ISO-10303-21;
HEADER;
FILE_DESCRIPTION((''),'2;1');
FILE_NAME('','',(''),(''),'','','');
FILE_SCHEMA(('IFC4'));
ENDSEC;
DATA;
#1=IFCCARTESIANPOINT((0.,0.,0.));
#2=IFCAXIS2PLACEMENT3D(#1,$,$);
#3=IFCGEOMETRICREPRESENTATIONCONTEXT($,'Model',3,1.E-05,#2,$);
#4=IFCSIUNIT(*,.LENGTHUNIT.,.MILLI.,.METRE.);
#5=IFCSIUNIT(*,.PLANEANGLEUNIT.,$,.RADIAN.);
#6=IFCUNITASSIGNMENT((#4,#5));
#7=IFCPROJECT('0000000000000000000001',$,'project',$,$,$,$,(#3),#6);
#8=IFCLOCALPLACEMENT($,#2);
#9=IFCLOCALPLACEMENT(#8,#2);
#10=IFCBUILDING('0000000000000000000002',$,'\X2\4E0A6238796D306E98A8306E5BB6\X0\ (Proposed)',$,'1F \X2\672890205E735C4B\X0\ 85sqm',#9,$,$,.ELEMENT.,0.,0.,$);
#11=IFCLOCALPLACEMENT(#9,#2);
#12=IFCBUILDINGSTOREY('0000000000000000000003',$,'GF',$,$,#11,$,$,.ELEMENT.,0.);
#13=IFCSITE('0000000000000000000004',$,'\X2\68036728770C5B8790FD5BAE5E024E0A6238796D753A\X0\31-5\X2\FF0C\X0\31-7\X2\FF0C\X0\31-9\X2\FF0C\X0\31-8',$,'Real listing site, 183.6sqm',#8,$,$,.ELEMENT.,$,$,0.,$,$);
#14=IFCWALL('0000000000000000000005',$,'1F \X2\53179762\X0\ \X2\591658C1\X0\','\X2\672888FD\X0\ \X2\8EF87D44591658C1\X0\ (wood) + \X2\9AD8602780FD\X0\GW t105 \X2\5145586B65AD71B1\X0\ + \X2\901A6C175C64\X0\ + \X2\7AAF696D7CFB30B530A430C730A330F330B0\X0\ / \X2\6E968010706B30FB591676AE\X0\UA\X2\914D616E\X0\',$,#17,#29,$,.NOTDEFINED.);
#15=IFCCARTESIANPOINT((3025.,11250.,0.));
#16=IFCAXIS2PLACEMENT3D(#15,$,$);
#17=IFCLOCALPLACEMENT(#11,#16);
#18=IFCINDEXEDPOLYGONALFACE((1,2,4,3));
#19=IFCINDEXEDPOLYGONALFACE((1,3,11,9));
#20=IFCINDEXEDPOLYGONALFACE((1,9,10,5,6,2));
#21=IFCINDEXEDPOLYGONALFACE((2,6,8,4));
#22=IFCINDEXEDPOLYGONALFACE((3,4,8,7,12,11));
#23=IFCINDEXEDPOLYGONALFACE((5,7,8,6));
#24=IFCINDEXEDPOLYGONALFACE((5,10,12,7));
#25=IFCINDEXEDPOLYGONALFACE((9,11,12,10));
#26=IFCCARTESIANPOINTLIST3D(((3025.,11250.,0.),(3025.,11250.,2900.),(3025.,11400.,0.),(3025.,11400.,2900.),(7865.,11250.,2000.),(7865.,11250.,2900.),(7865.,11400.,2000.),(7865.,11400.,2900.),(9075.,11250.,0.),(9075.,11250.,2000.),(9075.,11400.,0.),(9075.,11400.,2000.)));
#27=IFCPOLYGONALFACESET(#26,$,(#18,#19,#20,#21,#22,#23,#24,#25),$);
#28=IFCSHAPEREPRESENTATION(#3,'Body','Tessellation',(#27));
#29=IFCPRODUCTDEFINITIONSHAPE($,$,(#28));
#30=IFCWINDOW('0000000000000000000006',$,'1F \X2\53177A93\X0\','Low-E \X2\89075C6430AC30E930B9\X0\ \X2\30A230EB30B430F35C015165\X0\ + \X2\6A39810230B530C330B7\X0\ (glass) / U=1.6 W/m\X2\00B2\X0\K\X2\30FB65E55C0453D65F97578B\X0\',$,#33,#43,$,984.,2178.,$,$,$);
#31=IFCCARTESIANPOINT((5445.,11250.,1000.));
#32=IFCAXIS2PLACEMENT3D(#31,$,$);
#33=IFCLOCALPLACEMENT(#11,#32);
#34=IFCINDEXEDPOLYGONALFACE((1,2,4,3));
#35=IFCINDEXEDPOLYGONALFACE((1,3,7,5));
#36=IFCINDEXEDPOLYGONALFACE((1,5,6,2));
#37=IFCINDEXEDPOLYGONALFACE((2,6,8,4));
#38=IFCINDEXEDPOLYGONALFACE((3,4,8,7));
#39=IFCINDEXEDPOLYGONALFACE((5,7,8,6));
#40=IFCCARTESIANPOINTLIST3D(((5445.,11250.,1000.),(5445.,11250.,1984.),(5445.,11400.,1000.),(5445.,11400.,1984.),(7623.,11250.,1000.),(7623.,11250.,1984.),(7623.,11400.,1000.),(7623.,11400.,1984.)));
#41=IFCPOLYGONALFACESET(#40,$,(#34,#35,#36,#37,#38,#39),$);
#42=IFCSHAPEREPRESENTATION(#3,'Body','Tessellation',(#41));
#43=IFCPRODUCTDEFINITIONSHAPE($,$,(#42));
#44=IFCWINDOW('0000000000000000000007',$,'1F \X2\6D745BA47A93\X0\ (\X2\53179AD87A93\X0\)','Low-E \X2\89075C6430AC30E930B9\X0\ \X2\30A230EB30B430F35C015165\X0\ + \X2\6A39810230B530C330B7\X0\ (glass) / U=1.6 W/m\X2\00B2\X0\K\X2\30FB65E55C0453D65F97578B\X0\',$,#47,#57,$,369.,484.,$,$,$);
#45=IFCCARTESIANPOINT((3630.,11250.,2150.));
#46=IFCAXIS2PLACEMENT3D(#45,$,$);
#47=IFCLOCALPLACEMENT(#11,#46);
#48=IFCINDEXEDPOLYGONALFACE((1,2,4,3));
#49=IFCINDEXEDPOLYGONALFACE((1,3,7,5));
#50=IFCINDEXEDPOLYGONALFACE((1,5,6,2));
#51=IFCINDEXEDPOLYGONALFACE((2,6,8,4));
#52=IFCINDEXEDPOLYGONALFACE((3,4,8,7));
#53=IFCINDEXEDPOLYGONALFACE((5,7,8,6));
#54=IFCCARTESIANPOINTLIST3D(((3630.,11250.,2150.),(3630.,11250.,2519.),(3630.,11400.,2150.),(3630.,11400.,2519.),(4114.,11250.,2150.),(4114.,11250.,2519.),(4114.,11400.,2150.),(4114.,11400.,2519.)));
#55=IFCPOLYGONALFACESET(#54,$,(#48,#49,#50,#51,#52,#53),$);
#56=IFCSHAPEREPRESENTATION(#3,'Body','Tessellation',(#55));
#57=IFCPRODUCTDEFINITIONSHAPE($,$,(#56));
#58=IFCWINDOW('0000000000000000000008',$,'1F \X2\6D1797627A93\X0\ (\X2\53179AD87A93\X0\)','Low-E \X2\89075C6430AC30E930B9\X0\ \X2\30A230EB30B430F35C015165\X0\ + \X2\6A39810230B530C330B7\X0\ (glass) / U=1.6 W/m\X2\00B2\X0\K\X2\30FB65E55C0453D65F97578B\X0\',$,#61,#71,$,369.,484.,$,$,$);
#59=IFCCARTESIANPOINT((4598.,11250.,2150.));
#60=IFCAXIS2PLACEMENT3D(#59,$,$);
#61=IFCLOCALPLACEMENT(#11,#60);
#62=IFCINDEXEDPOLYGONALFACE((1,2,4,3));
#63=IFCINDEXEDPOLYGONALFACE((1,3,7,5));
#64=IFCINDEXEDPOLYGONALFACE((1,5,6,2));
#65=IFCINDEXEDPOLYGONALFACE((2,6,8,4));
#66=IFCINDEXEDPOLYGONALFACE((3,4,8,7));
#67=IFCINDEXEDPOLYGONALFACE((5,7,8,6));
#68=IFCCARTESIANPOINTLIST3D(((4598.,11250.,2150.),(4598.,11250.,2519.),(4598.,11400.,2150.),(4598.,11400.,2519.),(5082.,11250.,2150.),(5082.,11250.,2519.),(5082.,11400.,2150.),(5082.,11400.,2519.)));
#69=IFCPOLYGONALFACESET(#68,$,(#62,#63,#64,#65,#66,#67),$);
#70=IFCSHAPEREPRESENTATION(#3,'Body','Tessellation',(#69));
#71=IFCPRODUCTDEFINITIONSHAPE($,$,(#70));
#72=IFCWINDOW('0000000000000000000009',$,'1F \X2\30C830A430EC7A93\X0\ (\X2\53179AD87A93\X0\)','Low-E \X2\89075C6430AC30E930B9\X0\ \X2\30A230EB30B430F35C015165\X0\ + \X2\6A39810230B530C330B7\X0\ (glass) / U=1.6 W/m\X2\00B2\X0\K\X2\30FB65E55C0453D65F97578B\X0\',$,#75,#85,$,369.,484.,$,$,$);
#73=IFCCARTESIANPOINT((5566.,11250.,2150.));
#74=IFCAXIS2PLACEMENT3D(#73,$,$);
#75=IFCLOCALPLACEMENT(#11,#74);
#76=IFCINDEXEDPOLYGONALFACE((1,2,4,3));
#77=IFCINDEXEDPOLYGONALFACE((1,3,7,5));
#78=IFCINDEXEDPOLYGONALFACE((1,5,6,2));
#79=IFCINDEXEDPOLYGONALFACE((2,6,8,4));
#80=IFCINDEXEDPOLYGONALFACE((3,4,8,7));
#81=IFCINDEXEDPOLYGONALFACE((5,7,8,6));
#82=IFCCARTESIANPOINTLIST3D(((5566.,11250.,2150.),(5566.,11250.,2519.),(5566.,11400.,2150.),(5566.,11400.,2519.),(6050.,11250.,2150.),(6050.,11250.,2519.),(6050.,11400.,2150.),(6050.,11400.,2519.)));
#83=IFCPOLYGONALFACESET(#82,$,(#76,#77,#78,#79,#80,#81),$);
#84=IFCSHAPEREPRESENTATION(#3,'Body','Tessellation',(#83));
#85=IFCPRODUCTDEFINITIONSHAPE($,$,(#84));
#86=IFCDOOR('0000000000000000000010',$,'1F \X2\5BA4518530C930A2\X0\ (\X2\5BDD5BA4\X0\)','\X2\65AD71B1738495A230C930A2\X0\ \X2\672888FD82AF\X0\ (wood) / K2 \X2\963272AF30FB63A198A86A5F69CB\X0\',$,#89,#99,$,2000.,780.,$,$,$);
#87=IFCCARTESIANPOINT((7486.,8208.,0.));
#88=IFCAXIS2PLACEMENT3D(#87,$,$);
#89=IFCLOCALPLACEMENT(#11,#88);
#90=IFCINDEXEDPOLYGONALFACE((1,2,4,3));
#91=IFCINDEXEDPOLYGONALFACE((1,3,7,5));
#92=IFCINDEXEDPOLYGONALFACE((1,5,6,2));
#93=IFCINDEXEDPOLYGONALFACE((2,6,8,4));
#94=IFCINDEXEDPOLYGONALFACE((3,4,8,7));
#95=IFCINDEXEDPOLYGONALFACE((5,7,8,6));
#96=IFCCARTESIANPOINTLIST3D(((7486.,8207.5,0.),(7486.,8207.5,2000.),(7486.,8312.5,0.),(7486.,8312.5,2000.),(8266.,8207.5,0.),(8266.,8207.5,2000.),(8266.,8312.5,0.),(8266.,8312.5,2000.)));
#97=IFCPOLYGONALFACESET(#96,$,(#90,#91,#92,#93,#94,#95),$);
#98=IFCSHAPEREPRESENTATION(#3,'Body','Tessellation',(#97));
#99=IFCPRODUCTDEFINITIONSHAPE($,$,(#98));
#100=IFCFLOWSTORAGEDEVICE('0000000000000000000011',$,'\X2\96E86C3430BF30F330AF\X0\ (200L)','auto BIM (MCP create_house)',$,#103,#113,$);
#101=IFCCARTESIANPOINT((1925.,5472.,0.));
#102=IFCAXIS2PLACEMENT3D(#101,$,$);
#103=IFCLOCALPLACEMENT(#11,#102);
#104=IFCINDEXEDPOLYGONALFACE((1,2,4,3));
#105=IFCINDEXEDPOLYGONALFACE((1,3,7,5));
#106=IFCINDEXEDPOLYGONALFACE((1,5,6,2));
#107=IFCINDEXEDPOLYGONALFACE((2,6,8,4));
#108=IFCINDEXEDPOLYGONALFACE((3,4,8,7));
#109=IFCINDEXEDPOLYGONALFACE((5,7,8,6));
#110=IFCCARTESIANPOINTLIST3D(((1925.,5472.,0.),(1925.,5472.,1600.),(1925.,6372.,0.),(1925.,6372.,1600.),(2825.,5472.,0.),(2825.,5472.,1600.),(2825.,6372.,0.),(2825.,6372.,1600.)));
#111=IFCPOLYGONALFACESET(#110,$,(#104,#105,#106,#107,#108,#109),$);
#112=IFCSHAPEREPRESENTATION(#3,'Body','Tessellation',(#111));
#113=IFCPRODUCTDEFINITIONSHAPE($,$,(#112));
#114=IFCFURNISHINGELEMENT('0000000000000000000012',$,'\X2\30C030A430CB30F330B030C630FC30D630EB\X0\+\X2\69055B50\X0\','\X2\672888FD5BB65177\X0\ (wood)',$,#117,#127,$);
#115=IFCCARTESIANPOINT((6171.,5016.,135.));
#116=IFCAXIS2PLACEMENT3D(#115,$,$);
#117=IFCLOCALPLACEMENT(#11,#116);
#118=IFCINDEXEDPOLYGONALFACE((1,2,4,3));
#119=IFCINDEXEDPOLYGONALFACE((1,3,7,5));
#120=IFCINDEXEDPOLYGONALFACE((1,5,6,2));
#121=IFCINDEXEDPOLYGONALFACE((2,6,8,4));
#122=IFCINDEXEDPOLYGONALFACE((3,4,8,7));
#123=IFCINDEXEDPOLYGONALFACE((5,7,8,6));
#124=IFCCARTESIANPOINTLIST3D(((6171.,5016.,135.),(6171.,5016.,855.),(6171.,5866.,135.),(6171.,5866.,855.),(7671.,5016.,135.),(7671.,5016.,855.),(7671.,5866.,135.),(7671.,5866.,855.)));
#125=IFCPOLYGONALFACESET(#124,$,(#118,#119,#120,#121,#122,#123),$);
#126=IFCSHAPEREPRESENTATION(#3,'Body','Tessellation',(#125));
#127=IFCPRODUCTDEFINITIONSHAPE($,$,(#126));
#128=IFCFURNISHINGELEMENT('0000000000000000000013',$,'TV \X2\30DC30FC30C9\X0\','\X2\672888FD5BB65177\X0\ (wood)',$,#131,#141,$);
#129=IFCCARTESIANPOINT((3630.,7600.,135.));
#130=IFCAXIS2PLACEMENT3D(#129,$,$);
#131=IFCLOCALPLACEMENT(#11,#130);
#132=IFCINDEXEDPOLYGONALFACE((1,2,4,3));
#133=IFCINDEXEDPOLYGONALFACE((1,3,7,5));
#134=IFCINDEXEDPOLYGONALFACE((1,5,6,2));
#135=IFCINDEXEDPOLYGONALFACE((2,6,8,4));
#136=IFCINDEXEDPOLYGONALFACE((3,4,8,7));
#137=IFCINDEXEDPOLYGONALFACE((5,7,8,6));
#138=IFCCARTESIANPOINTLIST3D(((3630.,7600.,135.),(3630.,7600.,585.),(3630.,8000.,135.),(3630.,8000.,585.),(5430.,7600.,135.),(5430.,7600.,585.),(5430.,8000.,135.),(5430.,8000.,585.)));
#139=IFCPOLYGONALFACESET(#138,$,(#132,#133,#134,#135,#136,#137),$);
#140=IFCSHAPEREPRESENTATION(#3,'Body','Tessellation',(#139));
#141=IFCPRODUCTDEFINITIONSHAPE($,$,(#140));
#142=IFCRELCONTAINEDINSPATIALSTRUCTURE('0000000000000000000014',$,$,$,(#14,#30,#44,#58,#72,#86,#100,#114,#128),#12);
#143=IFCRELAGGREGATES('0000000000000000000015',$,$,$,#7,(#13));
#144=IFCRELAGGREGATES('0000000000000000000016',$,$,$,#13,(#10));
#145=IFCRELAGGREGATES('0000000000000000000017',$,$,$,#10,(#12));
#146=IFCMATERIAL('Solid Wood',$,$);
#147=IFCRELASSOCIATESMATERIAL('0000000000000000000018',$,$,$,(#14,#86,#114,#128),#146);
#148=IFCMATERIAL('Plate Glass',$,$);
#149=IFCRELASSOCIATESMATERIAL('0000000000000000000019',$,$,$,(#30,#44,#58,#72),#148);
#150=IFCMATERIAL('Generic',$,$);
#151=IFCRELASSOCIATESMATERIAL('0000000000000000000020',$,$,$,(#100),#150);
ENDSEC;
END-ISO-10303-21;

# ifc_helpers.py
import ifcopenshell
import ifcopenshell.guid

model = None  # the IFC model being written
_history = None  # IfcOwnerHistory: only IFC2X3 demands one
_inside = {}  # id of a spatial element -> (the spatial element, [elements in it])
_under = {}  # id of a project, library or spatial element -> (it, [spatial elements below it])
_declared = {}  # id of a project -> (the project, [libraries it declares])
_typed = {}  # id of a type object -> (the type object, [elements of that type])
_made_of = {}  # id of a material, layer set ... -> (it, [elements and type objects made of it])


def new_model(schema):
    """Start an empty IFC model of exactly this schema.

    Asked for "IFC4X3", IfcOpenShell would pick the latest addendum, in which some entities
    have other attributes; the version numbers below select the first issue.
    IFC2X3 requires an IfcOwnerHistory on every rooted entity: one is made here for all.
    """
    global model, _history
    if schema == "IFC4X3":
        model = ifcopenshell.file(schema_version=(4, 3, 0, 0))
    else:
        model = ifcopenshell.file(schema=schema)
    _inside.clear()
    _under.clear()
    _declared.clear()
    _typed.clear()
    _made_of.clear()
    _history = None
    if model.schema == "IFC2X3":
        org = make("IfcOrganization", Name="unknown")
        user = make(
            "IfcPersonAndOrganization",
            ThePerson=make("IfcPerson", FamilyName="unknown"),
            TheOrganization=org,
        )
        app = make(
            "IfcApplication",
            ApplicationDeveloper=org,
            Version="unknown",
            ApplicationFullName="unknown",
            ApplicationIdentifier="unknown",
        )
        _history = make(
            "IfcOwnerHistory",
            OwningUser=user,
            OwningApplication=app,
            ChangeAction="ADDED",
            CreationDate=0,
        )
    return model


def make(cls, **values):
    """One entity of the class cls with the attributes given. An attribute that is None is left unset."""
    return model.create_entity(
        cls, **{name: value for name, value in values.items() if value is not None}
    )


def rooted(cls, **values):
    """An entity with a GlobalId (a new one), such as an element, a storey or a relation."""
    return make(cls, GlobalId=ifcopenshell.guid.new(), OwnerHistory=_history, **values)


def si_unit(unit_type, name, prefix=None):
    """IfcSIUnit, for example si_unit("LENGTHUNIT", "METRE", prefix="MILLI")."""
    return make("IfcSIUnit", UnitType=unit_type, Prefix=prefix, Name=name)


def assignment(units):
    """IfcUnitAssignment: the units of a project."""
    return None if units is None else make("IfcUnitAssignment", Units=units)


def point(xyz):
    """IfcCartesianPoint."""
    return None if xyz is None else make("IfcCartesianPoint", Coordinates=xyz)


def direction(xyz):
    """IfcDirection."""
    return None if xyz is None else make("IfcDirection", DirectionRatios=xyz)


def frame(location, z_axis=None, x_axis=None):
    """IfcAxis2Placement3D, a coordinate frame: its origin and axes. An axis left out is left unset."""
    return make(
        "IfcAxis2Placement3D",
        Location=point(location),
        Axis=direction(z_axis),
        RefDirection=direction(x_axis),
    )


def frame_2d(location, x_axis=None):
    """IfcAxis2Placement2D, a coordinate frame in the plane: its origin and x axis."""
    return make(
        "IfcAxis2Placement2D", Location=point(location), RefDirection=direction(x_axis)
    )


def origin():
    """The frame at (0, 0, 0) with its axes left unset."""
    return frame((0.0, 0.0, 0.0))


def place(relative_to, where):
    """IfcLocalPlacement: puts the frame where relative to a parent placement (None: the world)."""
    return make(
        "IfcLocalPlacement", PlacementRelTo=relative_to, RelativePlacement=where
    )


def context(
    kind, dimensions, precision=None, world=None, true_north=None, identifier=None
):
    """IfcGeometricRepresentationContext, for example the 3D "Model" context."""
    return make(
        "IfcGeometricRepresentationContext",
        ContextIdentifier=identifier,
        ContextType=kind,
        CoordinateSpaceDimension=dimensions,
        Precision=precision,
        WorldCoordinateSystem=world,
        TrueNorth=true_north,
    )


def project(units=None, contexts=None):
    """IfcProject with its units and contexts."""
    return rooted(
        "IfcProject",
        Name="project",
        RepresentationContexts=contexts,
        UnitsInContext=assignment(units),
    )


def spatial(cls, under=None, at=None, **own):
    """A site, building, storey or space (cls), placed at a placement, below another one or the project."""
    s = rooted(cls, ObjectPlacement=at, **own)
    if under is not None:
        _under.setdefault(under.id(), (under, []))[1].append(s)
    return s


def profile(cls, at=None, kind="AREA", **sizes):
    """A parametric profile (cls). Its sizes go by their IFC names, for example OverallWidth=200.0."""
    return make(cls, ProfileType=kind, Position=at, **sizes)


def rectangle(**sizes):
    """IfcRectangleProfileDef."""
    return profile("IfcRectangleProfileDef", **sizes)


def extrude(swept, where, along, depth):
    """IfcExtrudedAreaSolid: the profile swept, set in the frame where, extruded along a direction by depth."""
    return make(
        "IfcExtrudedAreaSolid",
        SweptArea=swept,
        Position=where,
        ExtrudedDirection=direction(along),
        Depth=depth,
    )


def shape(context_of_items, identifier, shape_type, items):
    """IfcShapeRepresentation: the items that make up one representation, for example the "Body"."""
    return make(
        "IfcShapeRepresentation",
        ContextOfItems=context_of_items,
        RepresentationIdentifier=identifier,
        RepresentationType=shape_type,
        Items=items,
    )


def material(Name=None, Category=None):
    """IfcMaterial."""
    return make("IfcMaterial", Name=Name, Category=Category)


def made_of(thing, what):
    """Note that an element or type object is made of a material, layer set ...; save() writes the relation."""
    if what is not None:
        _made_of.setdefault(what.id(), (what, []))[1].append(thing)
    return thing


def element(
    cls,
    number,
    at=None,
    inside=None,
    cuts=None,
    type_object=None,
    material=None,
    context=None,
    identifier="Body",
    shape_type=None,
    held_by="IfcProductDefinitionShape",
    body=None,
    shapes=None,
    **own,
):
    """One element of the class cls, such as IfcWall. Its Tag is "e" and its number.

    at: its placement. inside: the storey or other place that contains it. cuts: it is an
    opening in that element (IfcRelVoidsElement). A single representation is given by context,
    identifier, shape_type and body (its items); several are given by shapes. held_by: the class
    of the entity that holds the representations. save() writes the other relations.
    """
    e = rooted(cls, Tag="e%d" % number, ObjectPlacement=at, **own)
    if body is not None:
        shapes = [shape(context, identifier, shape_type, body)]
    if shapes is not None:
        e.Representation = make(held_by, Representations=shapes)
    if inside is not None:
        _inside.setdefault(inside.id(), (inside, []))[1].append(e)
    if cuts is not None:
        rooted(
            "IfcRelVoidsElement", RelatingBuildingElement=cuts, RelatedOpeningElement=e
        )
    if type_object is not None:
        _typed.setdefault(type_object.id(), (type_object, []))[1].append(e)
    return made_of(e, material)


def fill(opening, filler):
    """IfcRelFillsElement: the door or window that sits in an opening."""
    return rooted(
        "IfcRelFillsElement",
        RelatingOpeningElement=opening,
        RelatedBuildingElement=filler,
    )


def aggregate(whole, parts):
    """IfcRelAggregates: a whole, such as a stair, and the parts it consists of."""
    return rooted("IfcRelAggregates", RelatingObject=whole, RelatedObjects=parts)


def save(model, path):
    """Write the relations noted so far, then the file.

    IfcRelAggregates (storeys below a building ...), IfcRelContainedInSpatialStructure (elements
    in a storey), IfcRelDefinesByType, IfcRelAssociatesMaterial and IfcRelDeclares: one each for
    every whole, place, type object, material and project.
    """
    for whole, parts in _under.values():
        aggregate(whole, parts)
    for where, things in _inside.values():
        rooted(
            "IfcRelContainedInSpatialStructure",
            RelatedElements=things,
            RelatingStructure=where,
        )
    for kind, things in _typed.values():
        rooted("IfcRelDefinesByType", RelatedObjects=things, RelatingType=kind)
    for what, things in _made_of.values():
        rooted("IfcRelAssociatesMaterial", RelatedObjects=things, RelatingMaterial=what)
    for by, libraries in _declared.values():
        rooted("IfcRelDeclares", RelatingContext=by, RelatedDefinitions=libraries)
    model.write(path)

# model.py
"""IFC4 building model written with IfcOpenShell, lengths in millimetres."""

from ifc_helpers import new_model, si_unit, frame, frame_2d, origin, place, context, project, spatial, rectangle, extrude, material, element, fill, save


model = new_model("IFC4")

# Units and contexts
model_context = context("Model", 3, precision=1e-05, world=origin())
ifc_project = project(units=[si_unit("LENGTHUNIT", "METRE", prefix="MILLI"), si_unit("PLANEANGLEUNIT", "RADIAN")], contexts=[model_context])

# Site, building, storey
site_placement = place(None, origin())
site = spatial("IfcSite", under=ifc_project, at=site_placement, Name="栃木県宇都宮市上戸祭町31-5，31-7，31-9，31-8", ObjectType="Real listing site, 183.6sqm", CompositionType="ELEMENT", RefElevation=0.0)
building_placement = place(site_placement, origin())
building = spatial("IfcBuilding", under=site, at=building_placement, Name="上戸祭の風の家 (Proposed)", ObjectType="1F 木造平屋 85sqm", CompositionType="ELEMENT", ElevationOfRefHeight=0.0, ElevationOfTerrain=0.0)
storey_placement = place(building_placement, origin())
storey = spatial("IfcBuildingStorey", under=building, at=storey_placement, Name="GF", CompositionType="ELEMENT", Elevation=0.0)

# Wall, openings, windows
ifc_material_1 = material(Name="Solid Wood")
wall_1_placement = place(storey_placement, frame((3025.0, 11250.0, 0.0)))
wall_1 = element("IfcWall", 1, at=wall_1_placement, inside=storey, material=ifc_material_1, Name="1F 北面 外壁", Description="木製 軸組外壁 (wood) + 高性能GW t105 充填断熱 + 通気層 + 窯業系サイディング / 準耐火・外皮UA配慮", PredefinedType="NOTDEFINED", context=model_context, shape_type="SweptSolid", body=[
    extrude(rectangle(XDim=6050.0, YDim=150.0, at=frame_2d((3025.0, 75.0))), frame((3025.0, 11250.0, 0.0)), (0.0, 0.0, 1.0), 2900.0),
])
opening_1_placement = place(storey_placement, frame((5445.0, 11250.0, 1000.0)))
opening_1 = element("IfcOpeningElement", 2, at=opening_1_placement, cuts=wall_1, PredefinedType="NOTDEFINED", context=model_context, shape_type="SweptSolid", body=[
    extrude(rectangle(XDim=2178.0, YDim=150.0, at=frame_2d((1089.0, 75.0))), frame((5445.0, 11250.0, 1000.0)), (0.0, 0.0, 1.0), 984.0),
])
opening_2_placement = place(storey_placement, frame((3630.0, 11250.0, 2150.0)))
opening_2 = element("IfcOpeningElement", 3, at=opening_2_placement, cuts=wall_1, PredefinedType="NOTDEFINED", context=model_context, shape_type="SweptSolid", body=[
    extrude(rectangle(XDim=484.0, YDim=150.0, at=frame_2d((242.0, 75.0))), frame((3630.0, 11250.0, 2150.0)), (0.0, 0.0, 1.0), 369.0),
])
opening_3_placement = place(storey_placement, frame((4598.0, 11250.0, 2150.0)))
opening_3 = element("IfcOpeningElement", 4, at=opening_3_placement, cuts=wall_1, PredefinedType="NOTDEFINED", context=model_context, shape_type="SweptSolid", body=[
    extrude(rectangle(XDim=484.0, YDim=150.0, at=frame_2d((242.0, 75.0))), frame((4598.0, 11250.0, 2150.0)), (0.0, 0.0, 1.0), 369.0),
])
opening_4_placement = place(storey_placement, frame((5566.0, 11250.0, 2150.0)))
opening_4 = element("IfcOpeningElement", 5, at=opening_4_placement, cuts=wall_1, PredefinedType="NOTDEFINED", context=model_context, shape_type="SweptSolid", body=[
    extrude(rectangle(XDim=484.0, YDim=150.0, at=frame_2d((242.0, 75.0))), frame((5566.0, 11250.0, 2150.0)), (0.0, 0.0, 1.0), 369.0),
])
ifc_material_2 = material(Name="Plate Glass")
window_1_placement = place(storey_placement, frame((5445.0, 11250.0, 1000.0)))
window_1 = element("IfcWindow", 6, at=window_1_placement, inside=storey, material=ifc_material_2, Name="1F 北窓", Description="Low-E 複層ガラス アルゴン封入 + 樹脂サッシ (glass) / U=1.6 W/m²K・日射取得型", OverallHeight=984.0, OverallWidth=2178.0, context=model_context, shape_type="SweptSolid", body=[
    extrude(rectangle(XDim=2178.0, YDim=150.0, at=frame_2d((1089.0, 75.0))), frame((5445.0, 11250.0, 1000.0)), (0.0, 0.0, 1.0), 984.0),
])
fill(opening_1, window_1)
window_2_placement = place(storey_placement, frame((3630.0, 11250.0, 2150.0)))
window_2 = element("IfcWindow", 7, at=window_2_placement, inside=storey, material=ifc_material_2, Name="1F 浴室窓 (北高窓)", Description="Low-E 複層ガラス アルゴン封入 + 樹脂サッシ (glass) / U=1.6 W/m²K・日射取得型", OverallHeight=369.0, OverallWidth=484.0, context=model_context, shape_type="SweptSolid", body=[
    extrude(rectangle(XDim=484.0, YDim=150.0, at=frame_2d((242.0, 75.0))), frame((3630.0, 11250.0, 2150.0)), (0.0, 0.0, 1.0), 369.0),
])
fill(opening_2, window_2)
window_3_placement = place(storey_placement, frame((4598.0, 11250.0, 2150.0)))
window_3 = element("IfcWindow", 8, at=window_3_placement, inside=storey, material=ifc_material_2, Name="1F 洗面窓 (北高窓)", Description="Low-E 複層ガラス アルゴン封入 + 樹脂サッシ (glass) / U=1.6 W/m²K・日射取得型", OverallHeight=369.0, OverallWidth=484.0, context=model_context, shape_type="SweptSolid", body=[
    extrude(rectangle(XDim=484.0, YDim=150.0, at=frame_2d((242.0, 75.0))), frame((4598.0, 11250.0, 2150.0)), (0.0, 0.0, 1.0), 369.0),
])
fill(opening_3, window_3)
window_4_placement = place(storey_placement, frame((5566.0, 11250.0, 2150.0)))
window_4 = element("IfcWindow", 9, at=window_4_placement, inside=storey, material=ifc_material_2, Name="1F トイレ窓 (北高窓)", Description="Low-E 複層ガラス アルゴン封入 + 樹脂サッシ (glass) / U=1.6 W/m²K・日射取得型", OverallHeight=369.0, OverallWidth=484.0, context=model_context, shape_type="SweptSolid", body=[
    extrude(rectangle(XDim=484.0, YDim=150.0, at=frame_2d((242.0, 75.0))), frame((5566.0, 11250.0, 2150.0)), (0.0, 0.0, 1.0), 369.0),
])
fill(opening_4, window_4)

# Door
door_1_placement = place(storey_placement, frame((7486.0, 8208.0, 0.0)))
element("IfcDoor", 10, at=door_1_placement, inside=storey, material=ifc_material_1, Name="1F 室内ドア (寝室)", Description="断熱玄関ドア 木製芯 (wood) / K2 防犯・採風機構", OverallHeight=2000.0, OverallWidth=780.0, context=model_context, shape_type="SweptSolid", body=[
    extrude(rectangle(XDim=780.0, YDim=105.0, at=frame_2d((390.0, 52.0))), frame((7486.0, 8208.0, 0.0)), (0.0, 0.0, 1.0), 2000.0),
])

# Flow storage device
ifc_material_3 = material(Name="Generic")
flow_storage_device_placement = place(storey_placement, frame((1925.0, 5472.0, 0.0)))
element("IfcFlowStorageDevice", 11, at=flow_storage_device_placement, inside=storey, material=ifc_material_3, Name="雨水タンク (200L)", Description="auto BIM (MCP create_house)", context=model_context, shape_type="SweptSolid", body=[
    extrude(rectangle(XDim=900.0, YDim=900.0, at=frame_2d((450.0, 450.0))), frame((1925.0, 5472.0, 0.0)), (0.0, 0.0, 1.0), 1600.0),
])

# Furnishing elements
furnishing_1_placement = place(storey_placement, frame((6171.0, 5016.0, 135.0)))
element("IfcFurnishingElement", 12, at=furnishing_1_placement, inside=storey, material=ifc_material_1, Name="ダイニングテーブル+椅子", Description="木製家具 (wood)", context=model_context, shape_type="SweptSolid", body=[
    extrude(rectangle(XDim=1500.0, YDim=850.0, at=frame_2d((750.0, 425.0))), frame((6171.0, 5016.0, 135.0)), (0.0, 0.0, 1.0), 720.0),
])
furnishing_2_placement = place(storey_placement, frame((3630.0, 7600.0, 135.0)))
element("IfcFurnishingElement", 13, at=furnishing_2_placement, inside=storey, material=ifc_material_1, Name="TV ボード", Description="木製家具 (wood)", context=model_context, shape_type="SweptSolid", body=[
    extrude(rectangle(XDim=1800.0, YDim=400.0, at=frame_2d((900.0, 200.0))), frame((3630.0, 7600.0, 135.0)), (0.0, 0.0, 1.0), 450.0),
])

save(model, "model.ifc")
